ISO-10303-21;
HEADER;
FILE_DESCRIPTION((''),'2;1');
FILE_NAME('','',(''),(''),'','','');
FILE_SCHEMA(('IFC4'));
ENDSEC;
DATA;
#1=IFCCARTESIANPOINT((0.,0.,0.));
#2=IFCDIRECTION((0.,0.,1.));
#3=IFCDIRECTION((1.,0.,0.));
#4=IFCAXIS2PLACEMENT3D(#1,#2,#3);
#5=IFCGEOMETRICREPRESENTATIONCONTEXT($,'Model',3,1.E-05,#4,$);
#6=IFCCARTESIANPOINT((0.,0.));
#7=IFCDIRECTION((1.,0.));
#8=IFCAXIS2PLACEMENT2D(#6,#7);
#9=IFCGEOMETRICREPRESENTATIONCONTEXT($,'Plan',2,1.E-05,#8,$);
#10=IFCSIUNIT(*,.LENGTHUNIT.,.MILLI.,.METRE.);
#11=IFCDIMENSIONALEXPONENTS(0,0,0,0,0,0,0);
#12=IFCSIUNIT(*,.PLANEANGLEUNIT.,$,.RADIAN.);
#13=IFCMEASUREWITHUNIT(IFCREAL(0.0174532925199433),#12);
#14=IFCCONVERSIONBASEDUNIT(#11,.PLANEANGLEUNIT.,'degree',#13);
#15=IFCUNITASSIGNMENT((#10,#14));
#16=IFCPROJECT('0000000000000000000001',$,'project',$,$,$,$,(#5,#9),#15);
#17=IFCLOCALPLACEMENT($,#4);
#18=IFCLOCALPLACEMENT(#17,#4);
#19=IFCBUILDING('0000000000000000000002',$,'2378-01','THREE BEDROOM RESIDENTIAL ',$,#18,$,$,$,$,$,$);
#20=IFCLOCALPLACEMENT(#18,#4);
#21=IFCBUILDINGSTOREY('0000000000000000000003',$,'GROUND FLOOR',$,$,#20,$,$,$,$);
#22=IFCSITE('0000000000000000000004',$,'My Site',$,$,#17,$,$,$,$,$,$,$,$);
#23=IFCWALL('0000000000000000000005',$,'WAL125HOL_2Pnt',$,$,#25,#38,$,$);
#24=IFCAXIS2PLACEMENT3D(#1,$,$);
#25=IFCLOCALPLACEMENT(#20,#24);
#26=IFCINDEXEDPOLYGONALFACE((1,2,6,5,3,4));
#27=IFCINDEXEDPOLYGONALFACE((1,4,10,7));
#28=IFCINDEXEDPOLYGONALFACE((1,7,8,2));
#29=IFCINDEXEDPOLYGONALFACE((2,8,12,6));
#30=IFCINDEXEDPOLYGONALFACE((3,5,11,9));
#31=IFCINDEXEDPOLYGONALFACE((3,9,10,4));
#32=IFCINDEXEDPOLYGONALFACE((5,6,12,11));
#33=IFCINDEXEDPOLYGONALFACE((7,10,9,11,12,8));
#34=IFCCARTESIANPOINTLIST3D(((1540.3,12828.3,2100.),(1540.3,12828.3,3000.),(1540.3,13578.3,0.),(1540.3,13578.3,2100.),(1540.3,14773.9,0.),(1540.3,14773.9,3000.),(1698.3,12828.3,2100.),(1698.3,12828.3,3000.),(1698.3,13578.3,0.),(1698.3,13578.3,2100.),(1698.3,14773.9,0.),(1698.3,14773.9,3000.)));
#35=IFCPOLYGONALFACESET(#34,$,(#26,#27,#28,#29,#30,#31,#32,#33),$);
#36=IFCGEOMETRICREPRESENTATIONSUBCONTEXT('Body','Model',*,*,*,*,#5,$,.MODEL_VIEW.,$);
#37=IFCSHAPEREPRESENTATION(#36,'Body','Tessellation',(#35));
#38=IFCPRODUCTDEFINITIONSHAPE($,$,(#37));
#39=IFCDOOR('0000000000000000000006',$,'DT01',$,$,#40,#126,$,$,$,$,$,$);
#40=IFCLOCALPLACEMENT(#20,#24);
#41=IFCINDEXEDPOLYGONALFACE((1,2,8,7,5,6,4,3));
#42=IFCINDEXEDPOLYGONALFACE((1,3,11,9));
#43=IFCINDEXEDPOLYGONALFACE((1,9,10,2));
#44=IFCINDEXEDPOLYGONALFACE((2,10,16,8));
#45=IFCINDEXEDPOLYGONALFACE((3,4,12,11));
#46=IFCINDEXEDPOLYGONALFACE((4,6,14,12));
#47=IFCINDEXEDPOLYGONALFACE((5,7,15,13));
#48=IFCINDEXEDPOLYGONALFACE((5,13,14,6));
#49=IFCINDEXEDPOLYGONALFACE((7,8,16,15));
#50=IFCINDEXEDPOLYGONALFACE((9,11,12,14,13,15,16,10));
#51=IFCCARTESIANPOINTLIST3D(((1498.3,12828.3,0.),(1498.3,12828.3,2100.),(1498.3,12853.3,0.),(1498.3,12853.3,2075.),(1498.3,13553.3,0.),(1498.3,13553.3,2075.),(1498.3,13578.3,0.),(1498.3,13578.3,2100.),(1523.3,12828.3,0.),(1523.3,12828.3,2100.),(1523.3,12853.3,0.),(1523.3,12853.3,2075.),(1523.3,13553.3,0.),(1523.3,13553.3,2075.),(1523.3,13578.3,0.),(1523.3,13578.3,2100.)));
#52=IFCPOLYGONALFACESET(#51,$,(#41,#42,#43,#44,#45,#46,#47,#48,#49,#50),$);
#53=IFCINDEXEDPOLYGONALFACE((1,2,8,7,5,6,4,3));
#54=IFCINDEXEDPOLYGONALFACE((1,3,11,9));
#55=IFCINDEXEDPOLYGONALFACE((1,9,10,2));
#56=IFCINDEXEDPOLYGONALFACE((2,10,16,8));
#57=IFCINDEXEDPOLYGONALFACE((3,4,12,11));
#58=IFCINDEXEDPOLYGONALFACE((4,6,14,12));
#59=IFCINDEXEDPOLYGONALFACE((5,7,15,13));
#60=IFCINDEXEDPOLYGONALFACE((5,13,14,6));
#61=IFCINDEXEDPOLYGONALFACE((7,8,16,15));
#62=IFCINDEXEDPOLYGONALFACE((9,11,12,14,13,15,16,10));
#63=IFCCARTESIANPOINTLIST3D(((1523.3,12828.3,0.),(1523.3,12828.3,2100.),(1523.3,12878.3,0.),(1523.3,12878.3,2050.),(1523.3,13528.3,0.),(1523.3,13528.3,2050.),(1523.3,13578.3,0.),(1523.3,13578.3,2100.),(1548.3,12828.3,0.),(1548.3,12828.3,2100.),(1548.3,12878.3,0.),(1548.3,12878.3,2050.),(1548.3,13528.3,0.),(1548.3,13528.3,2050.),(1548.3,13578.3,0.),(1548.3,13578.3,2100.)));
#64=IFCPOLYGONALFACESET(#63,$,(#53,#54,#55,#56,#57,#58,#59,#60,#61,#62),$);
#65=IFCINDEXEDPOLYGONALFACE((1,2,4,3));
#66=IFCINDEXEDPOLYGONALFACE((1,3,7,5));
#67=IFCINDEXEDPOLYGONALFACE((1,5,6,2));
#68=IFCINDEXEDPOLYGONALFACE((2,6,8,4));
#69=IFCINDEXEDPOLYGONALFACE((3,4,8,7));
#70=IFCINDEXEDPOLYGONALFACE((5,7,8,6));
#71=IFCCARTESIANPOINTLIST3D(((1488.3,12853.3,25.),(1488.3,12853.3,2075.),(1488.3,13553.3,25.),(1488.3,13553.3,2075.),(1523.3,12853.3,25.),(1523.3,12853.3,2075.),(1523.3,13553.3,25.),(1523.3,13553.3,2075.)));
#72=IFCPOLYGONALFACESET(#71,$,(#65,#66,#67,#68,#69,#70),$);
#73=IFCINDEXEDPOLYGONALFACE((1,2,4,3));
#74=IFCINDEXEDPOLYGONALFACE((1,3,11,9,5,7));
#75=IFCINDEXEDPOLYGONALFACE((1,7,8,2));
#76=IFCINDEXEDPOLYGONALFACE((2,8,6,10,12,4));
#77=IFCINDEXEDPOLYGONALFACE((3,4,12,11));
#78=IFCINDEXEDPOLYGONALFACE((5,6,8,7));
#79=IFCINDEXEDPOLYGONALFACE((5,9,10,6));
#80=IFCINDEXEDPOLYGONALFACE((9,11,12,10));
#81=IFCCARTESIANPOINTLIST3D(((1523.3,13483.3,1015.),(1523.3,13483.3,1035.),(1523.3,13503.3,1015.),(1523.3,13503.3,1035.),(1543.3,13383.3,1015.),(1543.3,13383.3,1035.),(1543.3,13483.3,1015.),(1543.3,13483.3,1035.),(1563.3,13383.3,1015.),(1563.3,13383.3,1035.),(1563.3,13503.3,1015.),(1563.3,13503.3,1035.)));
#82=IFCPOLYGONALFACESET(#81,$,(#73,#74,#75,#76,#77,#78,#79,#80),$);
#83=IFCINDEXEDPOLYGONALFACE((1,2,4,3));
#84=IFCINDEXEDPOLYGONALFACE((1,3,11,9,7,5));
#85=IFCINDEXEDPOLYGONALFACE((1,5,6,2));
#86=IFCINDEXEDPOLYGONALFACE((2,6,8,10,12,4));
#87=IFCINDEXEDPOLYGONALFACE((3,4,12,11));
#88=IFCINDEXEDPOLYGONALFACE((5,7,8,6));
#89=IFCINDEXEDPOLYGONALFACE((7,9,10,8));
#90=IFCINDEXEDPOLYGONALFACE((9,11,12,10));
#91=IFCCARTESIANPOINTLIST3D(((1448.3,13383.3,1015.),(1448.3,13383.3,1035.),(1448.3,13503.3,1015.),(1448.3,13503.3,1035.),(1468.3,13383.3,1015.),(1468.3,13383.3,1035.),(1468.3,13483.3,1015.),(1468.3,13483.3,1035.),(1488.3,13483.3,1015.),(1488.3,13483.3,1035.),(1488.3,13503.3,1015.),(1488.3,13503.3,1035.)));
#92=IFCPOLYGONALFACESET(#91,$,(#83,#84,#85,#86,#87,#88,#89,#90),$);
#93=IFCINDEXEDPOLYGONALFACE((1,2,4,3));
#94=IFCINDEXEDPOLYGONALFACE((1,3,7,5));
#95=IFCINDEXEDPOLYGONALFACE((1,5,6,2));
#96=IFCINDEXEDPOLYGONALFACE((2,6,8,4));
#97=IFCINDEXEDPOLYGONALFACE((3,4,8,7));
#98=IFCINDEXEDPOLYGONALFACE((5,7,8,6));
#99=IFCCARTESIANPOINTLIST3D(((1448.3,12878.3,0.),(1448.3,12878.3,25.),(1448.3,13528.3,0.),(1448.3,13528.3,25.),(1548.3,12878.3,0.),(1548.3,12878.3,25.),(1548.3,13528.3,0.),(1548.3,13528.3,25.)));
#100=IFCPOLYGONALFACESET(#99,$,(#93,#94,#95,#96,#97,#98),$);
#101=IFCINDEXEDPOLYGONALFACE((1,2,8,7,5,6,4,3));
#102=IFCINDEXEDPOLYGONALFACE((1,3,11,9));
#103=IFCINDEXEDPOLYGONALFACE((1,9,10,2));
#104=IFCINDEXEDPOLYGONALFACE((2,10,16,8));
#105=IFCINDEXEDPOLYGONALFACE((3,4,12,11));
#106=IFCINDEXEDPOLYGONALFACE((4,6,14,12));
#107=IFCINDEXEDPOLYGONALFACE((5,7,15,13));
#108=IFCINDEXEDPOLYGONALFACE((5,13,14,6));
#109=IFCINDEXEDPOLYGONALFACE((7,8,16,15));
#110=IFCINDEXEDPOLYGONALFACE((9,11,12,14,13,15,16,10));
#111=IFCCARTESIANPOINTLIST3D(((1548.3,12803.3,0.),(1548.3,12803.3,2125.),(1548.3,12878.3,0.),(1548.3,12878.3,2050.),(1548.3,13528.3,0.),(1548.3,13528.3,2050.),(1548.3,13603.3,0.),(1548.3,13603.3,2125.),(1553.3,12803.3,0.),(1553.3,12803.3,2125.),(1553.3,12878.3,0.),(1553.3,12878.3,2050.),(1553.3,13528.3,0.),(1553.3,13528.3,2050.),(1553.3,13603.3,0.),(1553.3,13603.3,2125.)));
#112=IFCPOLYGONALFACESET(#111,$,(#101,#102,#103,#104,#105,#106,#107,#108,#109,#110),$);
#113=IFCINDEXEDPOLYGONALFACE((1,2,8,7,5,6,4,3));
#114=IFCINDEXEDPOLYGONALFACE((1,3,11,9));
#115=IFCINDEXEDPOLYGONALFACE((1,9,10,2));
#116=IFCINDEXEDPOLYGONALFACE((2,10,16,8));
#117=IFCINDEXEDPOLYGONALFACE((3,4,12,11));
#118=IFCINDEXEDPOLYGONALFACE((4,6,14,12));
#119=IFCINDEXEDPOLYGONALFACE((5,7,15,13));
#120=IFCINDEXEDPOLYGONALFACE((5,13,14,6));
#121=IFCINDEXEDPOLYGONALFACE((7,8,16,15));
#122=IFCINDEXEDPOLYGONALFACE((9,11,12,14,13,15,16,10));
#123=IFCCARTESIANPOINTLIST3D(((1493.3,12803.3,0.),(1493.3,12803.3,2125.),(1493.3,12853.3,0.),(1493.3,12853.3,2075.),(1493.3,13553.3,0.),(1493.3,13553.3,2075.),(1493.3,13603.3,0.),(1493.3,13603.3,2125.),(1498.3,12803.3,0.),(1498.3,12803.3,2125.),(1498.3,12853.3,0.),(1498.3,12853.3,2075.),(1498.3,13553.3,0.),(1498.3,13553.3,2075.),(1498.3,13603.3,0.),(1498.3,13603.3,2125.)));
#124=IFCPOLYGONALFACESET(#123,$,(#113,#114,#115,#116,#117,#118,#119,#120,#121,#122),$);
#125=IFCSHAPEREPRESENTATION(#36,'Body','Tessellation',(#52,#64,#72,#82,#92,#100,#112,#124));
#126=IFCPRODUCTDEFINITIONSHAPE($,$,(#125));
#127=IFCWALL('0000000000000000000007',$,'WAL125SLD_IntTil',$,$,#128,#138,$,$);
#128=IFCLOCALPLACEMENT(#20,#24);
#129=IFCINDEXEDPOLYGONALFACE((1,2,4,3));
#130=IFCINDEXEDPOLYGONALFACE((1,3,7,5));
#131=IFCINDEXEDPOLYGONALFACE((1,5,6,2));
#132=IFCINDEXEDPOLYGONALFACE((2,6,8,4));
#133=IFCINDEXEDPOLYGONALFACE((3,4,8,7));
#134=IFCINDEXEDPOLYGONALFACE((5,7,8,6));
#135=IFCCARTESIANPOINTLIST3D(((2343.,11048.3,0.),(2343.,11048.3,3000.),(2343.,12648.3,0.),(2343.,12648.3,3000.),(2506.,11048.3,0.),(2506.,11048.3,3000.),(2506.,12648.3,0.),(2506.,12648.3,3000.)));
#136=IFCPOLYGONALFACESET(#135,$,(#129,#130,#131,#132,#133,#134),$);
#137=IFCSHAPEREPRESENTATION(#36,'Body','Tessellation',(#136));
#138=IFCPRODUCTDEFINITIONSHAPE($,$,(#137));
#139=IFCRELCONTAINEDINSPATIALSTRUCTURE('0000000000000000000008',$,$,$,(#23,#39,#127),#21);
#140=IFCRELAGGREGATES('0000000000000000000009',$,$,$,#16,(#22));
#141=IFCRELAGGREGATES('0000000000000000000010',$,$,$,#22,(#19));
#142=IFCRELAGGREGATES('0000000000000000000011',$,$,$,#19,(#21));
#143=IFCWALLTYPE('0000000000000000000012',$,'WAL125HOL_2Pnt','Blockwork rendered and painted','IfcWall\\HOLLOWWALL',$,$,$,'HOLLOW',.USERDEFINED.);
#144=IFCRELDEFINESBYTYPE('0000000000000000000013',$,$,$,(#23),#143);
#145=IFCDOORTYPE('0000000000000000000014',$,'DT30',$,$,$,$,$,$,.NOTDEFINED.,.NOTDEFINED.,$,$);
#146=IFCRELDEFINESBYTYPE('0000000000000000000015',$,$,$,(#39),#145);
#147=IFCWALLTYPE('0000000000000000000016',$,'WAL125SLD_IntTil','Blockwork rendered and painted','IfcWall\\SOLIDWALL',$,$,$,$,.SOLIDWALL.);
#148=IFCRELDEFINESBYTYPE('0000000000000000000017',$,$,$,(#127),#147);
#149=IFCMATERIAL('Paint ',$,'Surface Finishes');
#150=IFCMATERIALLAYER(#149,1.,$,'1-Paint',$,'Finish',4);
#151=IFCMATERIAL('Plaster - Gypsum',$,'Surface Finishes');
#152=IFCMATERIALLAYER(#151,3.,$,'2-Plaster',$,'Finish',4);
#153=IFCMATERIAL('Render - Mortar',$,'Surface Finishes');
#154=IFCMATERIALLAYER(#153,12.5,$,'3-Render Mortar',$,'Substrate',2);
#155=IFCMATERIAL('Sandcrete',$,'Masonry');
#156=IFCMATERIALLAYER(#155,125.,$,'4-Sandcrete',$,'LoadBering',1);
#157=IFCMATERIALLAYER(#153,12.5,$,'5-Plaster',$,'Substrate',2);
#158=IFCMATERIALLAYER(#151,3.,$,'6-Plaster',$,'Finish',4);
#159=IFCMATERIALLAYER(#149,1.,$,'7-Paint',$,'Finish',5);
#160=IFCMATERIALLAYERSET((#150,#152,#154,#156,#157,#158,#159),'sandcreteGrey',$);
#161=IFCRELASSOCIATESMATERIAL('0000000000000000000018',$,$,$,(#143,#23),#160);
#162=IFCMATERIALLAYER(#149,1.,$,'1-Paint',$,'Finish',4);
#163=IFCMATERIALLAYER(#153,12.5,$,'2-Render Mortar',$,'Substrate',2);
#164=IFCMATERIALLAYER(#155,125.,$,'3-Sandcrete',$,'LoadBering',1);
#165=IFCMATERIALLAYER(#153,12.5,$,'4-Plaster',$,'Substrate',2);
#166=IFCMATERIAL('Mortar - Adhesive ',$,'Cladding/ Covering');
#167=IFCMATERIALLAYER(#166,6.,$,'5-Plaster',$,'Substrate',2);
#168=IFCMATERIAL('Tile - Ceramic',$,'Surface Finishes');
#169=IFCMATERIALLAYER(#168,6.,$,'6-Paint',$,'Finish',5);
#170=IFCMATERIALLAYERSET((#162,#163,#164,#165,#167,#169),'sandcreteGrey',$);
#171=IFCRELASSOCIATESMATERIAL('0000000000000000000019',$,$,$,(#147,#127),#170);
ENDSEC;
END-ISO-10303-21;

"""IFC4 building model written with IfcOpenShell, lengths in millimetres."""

from ifc_helpers import new_model, entity, si_unit, converted_unit, frame, origin_with_axes, origin_2d_with_axis, place, context, subcontext, project, spatial, line, indexed_curve, outline, extrude, shape, source, transform, mapped, material, layer, layer_set, layer_usage, type_object, type_shapes, element, fill, save


model = new_model("IFC4")

# Units and contexts
model_context = context("Model", 3, precision=1e-05, world=origin_with_axes())
plan_context = context("Plan", 2, precision=1e-05, world=origin_2d_with_axis())
body_context_1 = subcontext(model_context, "Body", "Model", "MODEL_VIEW")
body_context_2 = subcontext(plan_context, "Body", "Plan", "PLAN_VIEW")
ifc_project = project(units=[si_unit("LENGTHUNIT", "METRE", prefix="MILLI"), converted_unit("PLANEANGLEUNIT", "degree", entity("IfcReal", 0.0174532925199433), si_unit("PLANEANGLEUNIT", "RADIAN"), dimensions=[0, 0, 0, 0, 0, 0, 0])], contexts=[model_context, plan_context])

# Site, building, storey
site_placement = place(None, origin_with_axes())
site = spatial("IfcSite", under=ifc_project, at=site_placement, Name="My Site")
building_placement = place(site_placement, origin_with_axes())
building = spatial("IfcBuilding", under=site, at=building_placement, Name="2378-01", Description="THREE BEDROOM RESIDENTIAL ")
storey_placement = place(building_placement, origin_with_axes())
storey = spatial("IfcBuildingStorey", under=building, at=storey_placement, Name="GROUND FLOOR")

# Wall, opening, door
ifc_material_1 = material(Name="Paint ", Category="Surface Finishes")
ifc_layer_1 = layer(ifc_material_1, 1.0, Name="1-Paint", Category="Finish", Priority=4)
ifc_material_2 = material(Name="Plaster - Gypsum", Category="Surface Finishes")
ifc_layer_2 = layer(ifc_material_2, 3.0, Name="2-Plaster", Category="Finish", Priority=4)
ifc_material_3 = material(Name="Render - Mortar", Category="Surface Finishes")
ifc_layer_3 = layer(ifc_material_3, 12.5, Name="3-Render Mortar", Category="Substrate", Priority=2)
ifc_material_4 = material(Name="Sandcrete", Category="Masonry")
ifc_layer_4 = layer(ifc_material_4, 125.0, Name="4-Sandcrete", Category="LoadBering", Priority=1)
ifc_layer_5 = layer(ifc_material_3, 12.5, Name="5-Plaster", Category="Substrate", Priority=2)
ifc_layer_6 = layer(ifc_material_2, 3.0, Name="6-Plaster", Category="Finish", Priority=4)
ifc_layer_7 = layer(ifc_material_1, 1.0, Name="7-Paint", Category="Finish", Priority=5)
ifc_layer_set_1 = layer_set([ifc_layer_1, ifc_layer_2, ifc_layer_3, ifc_layer_4, ifc_layer_5, ifc_layer_6, ifc_layer_7], Name="sandcreteGrey")
ifc_layer_usage_1 = layer_usage(ifc_layer_set_1, "AXIS2", "POSITIVE", 0.0)
wall_type_1 = type_object("IfcWallType", Name="WAL125HOL_2Pnt", Description="Blockwork rendered and painted", ApplicableOccurrence="IfcWall\\HOLLOWWALL", ElementType="HOLLOW", PredefinedType="USERDEFINED", material=ifc_layer_set_1)
wall_1_placement = place(storey_placement, frame((1540.3, 14773.9, 0.0), z_axis=(0.0, 0.0, 1.0), x_axis=(-0.000001, -1.0, 0.0)))
wall_1 = element("IfcWall", 1, at=wall_1_placement, inside=storey, type_object=wall_type_1, material=ifc_layer_usage_1, Name="WAL125HOL_2Pnt", context=body_context_1, shape_type="SweptSolid", body=[
    extrude(outline(indexed_curve([(0.0, 0.0), (0.0, 158.0), (1945.6, 158.0), (1945.6, 0.0), (0.0, 0.0)], self_intersect=False)), origin_with_axes(), (0.0, 0.0, 1.0), 3000.0),
])
shared_shape_1 = source(origin_with_axes(), body_context_1, "Body", "SweptSolid", [
    extrude(outline(indexed_curve([(0.0, 0.0), (750.0, 0.0), (750.0, 2100.0), (0.0, 2100.0)], segments=[line(1, 2, 3, 4, 1)])), frame((0.0, -100.0, 0.0), z_axis=(0.0, -1.0, 0.0), x_axis=(1.0, 0.0, 0.0)), (0.0, 0.0, -1.0), 380.0),
])
opening_1_placement = place(wall_1_placement, frame((1945.6, 158.0, 0.0), z_axis=(0.0, 0.0, 1.0), x_axis=(-1.0, 0.0, 0.0)))
opening_1 = element("IfcOpeningElement", 2, at=opening_1_placement, cuts=wall_1, PredefinedType="OPENING", context=body_context_1, shape_type="MappedRepresentation", body=[
    mapped(shared_shape_1, transform((0.0, 0.0, 0.0), x_axis=(1.0, 0.0, 0.0), y_axis=(0.0, 1.0, 0.0), z_axis=(0.0, 0.0, 1.0), scale=1.0)),
])
door_type_1 = type_object("IfcDoorType", Name="DT30", OperationType="NOTDEFINED", PredefinedType="NOTDEFINED")
shared_shape_2 = source(origin_with_axes(), body_context_1, "Body", "SweptSolid", [
    extrude(outline(indexed_curve([(0.0, 0.0), (0.0, 2100.0), (750.0, 2100.0), (750.0, 0.0), (725.0, 0.0), (725.0, 2075.0), (25.0, 2075.0), (25.0, 0.0)], segments=[line(1, 2, 3, 4, 5, 6, 7, 8, 1)])), frame((0.0, 25.0, 0.0), z_axis=(0.0, -1.0, 0.0), x_axis=(1.0, 0.0, 0.0)), (0.0, 0.0, -1.0), 25.0),
    extrude(outline(indexed_curve([(0.0, 0.0), (0.0, 2100.0), (750.0, 2100.0), (750.0, 0.0), (700.0, 0.0), (700.0, 2050.0), (50.0, 2050.0), (50.0, 0.0)], segments=[line(1, 2, 3, 4, 5, 6, 7, 8, 1)])), frame((0.0, 0.0, 0.0), z_axis=(0.0, -1.0, 0.0), x_axis=(1.0, 0.0, 0.0)), (0.0, 0.0, -1.0), 25.0),
    extrude(outline(indexed_curve([(0.0, 0.0), (700.0, 0.0), (700.0, 35.0), (0.0, 35.0)], segments=[line(1, 2, 3, 4, 1)])), frame((25.0, 25.0, 25.0), z_axis=(0.0, 0.0, 1.0), x_axis=(1.0, 0.0, 0.0)), (0.0, 0.0, 1.0), 2050.0),
    extrude(outline(indexed_curve([(0.0, 0.0), (0.0, -40.0), (-120.0, -40.0), (-120.0, -20.0), (-20.0, -20.0), (-20.0, 0.0)], segments=[line(1, 2, 3, 4, 5, 6, 1)])), frame((675.0, 25.0, 1015.0), z_axis=(0.0, 0.0, 1.0), x_axis=(1.0, 0.0, 0.0)), (0.0, 0.0, 1.0), 20.0),
    extrude(outline(indexed_curve([(0.0, 0.0), (0.0, 40.0), (-120.0, 40.0), (-120.0, 20.0), (-20.0, 20.0), (-20.0, 0.0)], segments=[line(1, 2, 3, 4, 5, 6, 1)])), frame((675.0, 60.0, 1015.0), z_axis=(0.0, 0.0, 1.0), x_axis=(1.0, 0.0, 0.0)), (0.0, 0.0, 1.0), 20.0),
    extrude(outline(indexed_curve([(0.0, 0.0), (650.0, 0.0), (650.0, 100.0), (0.0, 100.0)], segments=[line(1, 2, 3, 4, 1)])), frame((50.0, 0.0, 0.0), z_axis=(0.0, 0.0, 1.0), x_axis=(1.0, 0.0, 0.0)), (0.0, 0.0, 1.0), 25.0),
    extrude(outline(indexed_curve([(0.0, 0.0), (0.0, 2125.0), (800.0, 2125.0), (800.0, 0.0), (725.0, 0.0), (725.0, 2050.0), (75.0, 2050.0), (75.0, 0.0)], segments=[line(1, 2, 3, 4, 5, 6, 7, 8, 1)])), frame((-25.0, -5.0, 0.0), z_axis=(0.0, -1.0, 0.0), x_axis=(1.0, 0.0, 0.0)), (0.0, 0.0, -1.0), 5.0),
    extrude(outline(indexed_curve([(0.0, 0.0), (0.0, 2125.0), (800.0, 2125.0), (800.0, 0.0), (750.0, 0.0), (750.0, 2075.0), (50.0, 2075.0), (50.0, 0.0)], segments=[line(1, 2, 3, 4, 5, 6, 7, 8, 1)])), frame((-25.0, 50.0, 0.0), z_axis=(0.0, -1.0, 0.0), x_axis=(1.0, 0.0, 0.0)), (0.0, 0.0, -1.0), 5.0),
])
shared_shape_3 = source(origin_with_axes(), body_context_2, "Body", "Curve2D", [
    entity("IfcIndexedPolyCurve", entity("IfcCartesianPointList2D", [[0.0, 0.0], [0.0, 50.0], [25.0, 50.0], [25.0, 25.0], [50.0, 25.0], [50.0, 0.0]]), [entity("IfcLineIndex", [1, 2, 3, 4, 5, 6, 1])]),
    entity("IfcIndexedPolyCurve", entity("IfcCartesianPointList2D", [[750.0, 0.0], [750.0, 50.0], [725.0, 50.0], [725.0, 25.0], [700.0, 25.0], [700.0, 0.0]]), [entity("IfcLineIndex", [1, 2, 3, 4, 5, 6, 1])]),
    entity("IfcTrimmedCurve", entity("IfcEllipse", entity("IfcAxis2Placement2D", entity("IfcCartesianPoint", [60.0, 50.0]), entity("IfcDirection", [1.0, 0.0])), 665.0, 700.0), [entity("IfcCartesianPoint", [725.0, 50.0])], [entity("IfcCartesianPoint", [60.0, 750.0])], True, "CARTESIAN"),
    entity("IfcIndexedPolyCurve", entity("IfcCartesianPointList2D", [[25.0, 50.0], [60.0, 50.0], [60.0, 750.0], [25.0, 750.0]]), [entity("IfcLineIndex", [1, 2, 3, 4, 1])]),
])
type_shapes(door_type_1, [shared_shape_2, shared_shape_3])
door_1_placement = place(opening_1_placement, frame((0.0, 150.0, 0.0), z_axis=(0.0, 0.0, 1.0), x_axis=(1.0, 0.0, 0.0)))
door_1 = element("IfcDoor", 3, at=door_1_placement, inside=storey, type_object=door_type_1, Name="DT01", shapes=[
    shape(body_context_1, "Body", "MappedRepresentation", [mapped(shared_shape_2, transform((0.0, 0.0, 0.0), x_axis=(1.0, 0.0, 0.0), y_axis=(0.0, 1.0, 0.0), z_axis=(0.0, 0.0, 1.0), scale=1.0))]),
    shape(body_context_2, "Body", "MappedRepresentation", [mapped(shared_shape_3, transform((0.0, 0.0, 0.0), x_axis=(1.0, 0.0, 0.0), y_axis=(0.0, 1.0, 0.0), z_axis=(0.0, 0.0, 1.0), scale=1.0))]),
])
fill(opening_1, door_1)

# Wall
ifc_layer_8 = layer(ifc_material_1, 1.0, Name="1-Paint", Category="Finish", Priority=4)
ifc_layer_9 = layer(ifc_material_3, 12.5, Name="2-Render Mortar", Category="Substrate", Priority=2)
ifc_layer_10 = layer(ifc_material_4, 125.0, Name="3-Sandcrete", Category="LoadBering", Priority=1)
ifc_layer_11 = layer(ifc_material_3, 12.5, Name="4-Plaster", Category="Substrate", Priority=2)
ifc_material_5 = material(Name="Mortar - Adhesive ", Category="Cladding/ Covering")
ifc_layer_12 = layer(ifc_material_5, 6.0, Name="5-Plaster", Category="Substrate", Priority=2)
ifc_material_6 = material(Name="Tile - Ceramic", Category="Surface Finishes")
ifc_layer_13 = layer(ifc_material_6, 6.0, Name="6-Paint", Category="Finish", Priority=5)
ifc_layer_set_2 = layer_set([ifc_layer_8, ifc_layer_9, ifc_layer_10, ifc_layer_11, ifc_layer_12, ifc_layer_13], Name="sandcreteGrey")
ifc_layer_usage_2 = layer_usage(ifc_layer_set_2, "AXIS2", "POSITIVE", 0.0)
wall_type_2 = type_object("IfcWallType", Name="WAL125SLD_IntTil", Description="Blockwork rendered and painted", ApplicableOccurrence="IfcWall\\SOLIDWALL", PredefinedType="SOLIDWALL", material=ifc_layer_set_2)
wall_2_placement = place(storey_placement, frame((2506.0, 11048.3, 0.0), z_axis=(0.0, 0.0, 1.0), x_axis=(0.0, 1.0, 0.0)))
element("IfcWall", 4, at=wall_2_placement, inside=storey, type_object=wall_type_2, material=ifc_layer_usage_2, Name="WAL125SLD_IntTil", context=body_context_1, shape_type="SweptSolid", body=[
    extrude(outline(indexed_curve([(0.0, 0.0), (0.0, 163.0), (1600.0, 163.0), (1600.0, 0.0), (0.0, 0.0)], self_intersect=False)), origin_with_axes(), (0.0, 0.0, 1.0), 3000.0),
])

save(model, "model.ifc")
